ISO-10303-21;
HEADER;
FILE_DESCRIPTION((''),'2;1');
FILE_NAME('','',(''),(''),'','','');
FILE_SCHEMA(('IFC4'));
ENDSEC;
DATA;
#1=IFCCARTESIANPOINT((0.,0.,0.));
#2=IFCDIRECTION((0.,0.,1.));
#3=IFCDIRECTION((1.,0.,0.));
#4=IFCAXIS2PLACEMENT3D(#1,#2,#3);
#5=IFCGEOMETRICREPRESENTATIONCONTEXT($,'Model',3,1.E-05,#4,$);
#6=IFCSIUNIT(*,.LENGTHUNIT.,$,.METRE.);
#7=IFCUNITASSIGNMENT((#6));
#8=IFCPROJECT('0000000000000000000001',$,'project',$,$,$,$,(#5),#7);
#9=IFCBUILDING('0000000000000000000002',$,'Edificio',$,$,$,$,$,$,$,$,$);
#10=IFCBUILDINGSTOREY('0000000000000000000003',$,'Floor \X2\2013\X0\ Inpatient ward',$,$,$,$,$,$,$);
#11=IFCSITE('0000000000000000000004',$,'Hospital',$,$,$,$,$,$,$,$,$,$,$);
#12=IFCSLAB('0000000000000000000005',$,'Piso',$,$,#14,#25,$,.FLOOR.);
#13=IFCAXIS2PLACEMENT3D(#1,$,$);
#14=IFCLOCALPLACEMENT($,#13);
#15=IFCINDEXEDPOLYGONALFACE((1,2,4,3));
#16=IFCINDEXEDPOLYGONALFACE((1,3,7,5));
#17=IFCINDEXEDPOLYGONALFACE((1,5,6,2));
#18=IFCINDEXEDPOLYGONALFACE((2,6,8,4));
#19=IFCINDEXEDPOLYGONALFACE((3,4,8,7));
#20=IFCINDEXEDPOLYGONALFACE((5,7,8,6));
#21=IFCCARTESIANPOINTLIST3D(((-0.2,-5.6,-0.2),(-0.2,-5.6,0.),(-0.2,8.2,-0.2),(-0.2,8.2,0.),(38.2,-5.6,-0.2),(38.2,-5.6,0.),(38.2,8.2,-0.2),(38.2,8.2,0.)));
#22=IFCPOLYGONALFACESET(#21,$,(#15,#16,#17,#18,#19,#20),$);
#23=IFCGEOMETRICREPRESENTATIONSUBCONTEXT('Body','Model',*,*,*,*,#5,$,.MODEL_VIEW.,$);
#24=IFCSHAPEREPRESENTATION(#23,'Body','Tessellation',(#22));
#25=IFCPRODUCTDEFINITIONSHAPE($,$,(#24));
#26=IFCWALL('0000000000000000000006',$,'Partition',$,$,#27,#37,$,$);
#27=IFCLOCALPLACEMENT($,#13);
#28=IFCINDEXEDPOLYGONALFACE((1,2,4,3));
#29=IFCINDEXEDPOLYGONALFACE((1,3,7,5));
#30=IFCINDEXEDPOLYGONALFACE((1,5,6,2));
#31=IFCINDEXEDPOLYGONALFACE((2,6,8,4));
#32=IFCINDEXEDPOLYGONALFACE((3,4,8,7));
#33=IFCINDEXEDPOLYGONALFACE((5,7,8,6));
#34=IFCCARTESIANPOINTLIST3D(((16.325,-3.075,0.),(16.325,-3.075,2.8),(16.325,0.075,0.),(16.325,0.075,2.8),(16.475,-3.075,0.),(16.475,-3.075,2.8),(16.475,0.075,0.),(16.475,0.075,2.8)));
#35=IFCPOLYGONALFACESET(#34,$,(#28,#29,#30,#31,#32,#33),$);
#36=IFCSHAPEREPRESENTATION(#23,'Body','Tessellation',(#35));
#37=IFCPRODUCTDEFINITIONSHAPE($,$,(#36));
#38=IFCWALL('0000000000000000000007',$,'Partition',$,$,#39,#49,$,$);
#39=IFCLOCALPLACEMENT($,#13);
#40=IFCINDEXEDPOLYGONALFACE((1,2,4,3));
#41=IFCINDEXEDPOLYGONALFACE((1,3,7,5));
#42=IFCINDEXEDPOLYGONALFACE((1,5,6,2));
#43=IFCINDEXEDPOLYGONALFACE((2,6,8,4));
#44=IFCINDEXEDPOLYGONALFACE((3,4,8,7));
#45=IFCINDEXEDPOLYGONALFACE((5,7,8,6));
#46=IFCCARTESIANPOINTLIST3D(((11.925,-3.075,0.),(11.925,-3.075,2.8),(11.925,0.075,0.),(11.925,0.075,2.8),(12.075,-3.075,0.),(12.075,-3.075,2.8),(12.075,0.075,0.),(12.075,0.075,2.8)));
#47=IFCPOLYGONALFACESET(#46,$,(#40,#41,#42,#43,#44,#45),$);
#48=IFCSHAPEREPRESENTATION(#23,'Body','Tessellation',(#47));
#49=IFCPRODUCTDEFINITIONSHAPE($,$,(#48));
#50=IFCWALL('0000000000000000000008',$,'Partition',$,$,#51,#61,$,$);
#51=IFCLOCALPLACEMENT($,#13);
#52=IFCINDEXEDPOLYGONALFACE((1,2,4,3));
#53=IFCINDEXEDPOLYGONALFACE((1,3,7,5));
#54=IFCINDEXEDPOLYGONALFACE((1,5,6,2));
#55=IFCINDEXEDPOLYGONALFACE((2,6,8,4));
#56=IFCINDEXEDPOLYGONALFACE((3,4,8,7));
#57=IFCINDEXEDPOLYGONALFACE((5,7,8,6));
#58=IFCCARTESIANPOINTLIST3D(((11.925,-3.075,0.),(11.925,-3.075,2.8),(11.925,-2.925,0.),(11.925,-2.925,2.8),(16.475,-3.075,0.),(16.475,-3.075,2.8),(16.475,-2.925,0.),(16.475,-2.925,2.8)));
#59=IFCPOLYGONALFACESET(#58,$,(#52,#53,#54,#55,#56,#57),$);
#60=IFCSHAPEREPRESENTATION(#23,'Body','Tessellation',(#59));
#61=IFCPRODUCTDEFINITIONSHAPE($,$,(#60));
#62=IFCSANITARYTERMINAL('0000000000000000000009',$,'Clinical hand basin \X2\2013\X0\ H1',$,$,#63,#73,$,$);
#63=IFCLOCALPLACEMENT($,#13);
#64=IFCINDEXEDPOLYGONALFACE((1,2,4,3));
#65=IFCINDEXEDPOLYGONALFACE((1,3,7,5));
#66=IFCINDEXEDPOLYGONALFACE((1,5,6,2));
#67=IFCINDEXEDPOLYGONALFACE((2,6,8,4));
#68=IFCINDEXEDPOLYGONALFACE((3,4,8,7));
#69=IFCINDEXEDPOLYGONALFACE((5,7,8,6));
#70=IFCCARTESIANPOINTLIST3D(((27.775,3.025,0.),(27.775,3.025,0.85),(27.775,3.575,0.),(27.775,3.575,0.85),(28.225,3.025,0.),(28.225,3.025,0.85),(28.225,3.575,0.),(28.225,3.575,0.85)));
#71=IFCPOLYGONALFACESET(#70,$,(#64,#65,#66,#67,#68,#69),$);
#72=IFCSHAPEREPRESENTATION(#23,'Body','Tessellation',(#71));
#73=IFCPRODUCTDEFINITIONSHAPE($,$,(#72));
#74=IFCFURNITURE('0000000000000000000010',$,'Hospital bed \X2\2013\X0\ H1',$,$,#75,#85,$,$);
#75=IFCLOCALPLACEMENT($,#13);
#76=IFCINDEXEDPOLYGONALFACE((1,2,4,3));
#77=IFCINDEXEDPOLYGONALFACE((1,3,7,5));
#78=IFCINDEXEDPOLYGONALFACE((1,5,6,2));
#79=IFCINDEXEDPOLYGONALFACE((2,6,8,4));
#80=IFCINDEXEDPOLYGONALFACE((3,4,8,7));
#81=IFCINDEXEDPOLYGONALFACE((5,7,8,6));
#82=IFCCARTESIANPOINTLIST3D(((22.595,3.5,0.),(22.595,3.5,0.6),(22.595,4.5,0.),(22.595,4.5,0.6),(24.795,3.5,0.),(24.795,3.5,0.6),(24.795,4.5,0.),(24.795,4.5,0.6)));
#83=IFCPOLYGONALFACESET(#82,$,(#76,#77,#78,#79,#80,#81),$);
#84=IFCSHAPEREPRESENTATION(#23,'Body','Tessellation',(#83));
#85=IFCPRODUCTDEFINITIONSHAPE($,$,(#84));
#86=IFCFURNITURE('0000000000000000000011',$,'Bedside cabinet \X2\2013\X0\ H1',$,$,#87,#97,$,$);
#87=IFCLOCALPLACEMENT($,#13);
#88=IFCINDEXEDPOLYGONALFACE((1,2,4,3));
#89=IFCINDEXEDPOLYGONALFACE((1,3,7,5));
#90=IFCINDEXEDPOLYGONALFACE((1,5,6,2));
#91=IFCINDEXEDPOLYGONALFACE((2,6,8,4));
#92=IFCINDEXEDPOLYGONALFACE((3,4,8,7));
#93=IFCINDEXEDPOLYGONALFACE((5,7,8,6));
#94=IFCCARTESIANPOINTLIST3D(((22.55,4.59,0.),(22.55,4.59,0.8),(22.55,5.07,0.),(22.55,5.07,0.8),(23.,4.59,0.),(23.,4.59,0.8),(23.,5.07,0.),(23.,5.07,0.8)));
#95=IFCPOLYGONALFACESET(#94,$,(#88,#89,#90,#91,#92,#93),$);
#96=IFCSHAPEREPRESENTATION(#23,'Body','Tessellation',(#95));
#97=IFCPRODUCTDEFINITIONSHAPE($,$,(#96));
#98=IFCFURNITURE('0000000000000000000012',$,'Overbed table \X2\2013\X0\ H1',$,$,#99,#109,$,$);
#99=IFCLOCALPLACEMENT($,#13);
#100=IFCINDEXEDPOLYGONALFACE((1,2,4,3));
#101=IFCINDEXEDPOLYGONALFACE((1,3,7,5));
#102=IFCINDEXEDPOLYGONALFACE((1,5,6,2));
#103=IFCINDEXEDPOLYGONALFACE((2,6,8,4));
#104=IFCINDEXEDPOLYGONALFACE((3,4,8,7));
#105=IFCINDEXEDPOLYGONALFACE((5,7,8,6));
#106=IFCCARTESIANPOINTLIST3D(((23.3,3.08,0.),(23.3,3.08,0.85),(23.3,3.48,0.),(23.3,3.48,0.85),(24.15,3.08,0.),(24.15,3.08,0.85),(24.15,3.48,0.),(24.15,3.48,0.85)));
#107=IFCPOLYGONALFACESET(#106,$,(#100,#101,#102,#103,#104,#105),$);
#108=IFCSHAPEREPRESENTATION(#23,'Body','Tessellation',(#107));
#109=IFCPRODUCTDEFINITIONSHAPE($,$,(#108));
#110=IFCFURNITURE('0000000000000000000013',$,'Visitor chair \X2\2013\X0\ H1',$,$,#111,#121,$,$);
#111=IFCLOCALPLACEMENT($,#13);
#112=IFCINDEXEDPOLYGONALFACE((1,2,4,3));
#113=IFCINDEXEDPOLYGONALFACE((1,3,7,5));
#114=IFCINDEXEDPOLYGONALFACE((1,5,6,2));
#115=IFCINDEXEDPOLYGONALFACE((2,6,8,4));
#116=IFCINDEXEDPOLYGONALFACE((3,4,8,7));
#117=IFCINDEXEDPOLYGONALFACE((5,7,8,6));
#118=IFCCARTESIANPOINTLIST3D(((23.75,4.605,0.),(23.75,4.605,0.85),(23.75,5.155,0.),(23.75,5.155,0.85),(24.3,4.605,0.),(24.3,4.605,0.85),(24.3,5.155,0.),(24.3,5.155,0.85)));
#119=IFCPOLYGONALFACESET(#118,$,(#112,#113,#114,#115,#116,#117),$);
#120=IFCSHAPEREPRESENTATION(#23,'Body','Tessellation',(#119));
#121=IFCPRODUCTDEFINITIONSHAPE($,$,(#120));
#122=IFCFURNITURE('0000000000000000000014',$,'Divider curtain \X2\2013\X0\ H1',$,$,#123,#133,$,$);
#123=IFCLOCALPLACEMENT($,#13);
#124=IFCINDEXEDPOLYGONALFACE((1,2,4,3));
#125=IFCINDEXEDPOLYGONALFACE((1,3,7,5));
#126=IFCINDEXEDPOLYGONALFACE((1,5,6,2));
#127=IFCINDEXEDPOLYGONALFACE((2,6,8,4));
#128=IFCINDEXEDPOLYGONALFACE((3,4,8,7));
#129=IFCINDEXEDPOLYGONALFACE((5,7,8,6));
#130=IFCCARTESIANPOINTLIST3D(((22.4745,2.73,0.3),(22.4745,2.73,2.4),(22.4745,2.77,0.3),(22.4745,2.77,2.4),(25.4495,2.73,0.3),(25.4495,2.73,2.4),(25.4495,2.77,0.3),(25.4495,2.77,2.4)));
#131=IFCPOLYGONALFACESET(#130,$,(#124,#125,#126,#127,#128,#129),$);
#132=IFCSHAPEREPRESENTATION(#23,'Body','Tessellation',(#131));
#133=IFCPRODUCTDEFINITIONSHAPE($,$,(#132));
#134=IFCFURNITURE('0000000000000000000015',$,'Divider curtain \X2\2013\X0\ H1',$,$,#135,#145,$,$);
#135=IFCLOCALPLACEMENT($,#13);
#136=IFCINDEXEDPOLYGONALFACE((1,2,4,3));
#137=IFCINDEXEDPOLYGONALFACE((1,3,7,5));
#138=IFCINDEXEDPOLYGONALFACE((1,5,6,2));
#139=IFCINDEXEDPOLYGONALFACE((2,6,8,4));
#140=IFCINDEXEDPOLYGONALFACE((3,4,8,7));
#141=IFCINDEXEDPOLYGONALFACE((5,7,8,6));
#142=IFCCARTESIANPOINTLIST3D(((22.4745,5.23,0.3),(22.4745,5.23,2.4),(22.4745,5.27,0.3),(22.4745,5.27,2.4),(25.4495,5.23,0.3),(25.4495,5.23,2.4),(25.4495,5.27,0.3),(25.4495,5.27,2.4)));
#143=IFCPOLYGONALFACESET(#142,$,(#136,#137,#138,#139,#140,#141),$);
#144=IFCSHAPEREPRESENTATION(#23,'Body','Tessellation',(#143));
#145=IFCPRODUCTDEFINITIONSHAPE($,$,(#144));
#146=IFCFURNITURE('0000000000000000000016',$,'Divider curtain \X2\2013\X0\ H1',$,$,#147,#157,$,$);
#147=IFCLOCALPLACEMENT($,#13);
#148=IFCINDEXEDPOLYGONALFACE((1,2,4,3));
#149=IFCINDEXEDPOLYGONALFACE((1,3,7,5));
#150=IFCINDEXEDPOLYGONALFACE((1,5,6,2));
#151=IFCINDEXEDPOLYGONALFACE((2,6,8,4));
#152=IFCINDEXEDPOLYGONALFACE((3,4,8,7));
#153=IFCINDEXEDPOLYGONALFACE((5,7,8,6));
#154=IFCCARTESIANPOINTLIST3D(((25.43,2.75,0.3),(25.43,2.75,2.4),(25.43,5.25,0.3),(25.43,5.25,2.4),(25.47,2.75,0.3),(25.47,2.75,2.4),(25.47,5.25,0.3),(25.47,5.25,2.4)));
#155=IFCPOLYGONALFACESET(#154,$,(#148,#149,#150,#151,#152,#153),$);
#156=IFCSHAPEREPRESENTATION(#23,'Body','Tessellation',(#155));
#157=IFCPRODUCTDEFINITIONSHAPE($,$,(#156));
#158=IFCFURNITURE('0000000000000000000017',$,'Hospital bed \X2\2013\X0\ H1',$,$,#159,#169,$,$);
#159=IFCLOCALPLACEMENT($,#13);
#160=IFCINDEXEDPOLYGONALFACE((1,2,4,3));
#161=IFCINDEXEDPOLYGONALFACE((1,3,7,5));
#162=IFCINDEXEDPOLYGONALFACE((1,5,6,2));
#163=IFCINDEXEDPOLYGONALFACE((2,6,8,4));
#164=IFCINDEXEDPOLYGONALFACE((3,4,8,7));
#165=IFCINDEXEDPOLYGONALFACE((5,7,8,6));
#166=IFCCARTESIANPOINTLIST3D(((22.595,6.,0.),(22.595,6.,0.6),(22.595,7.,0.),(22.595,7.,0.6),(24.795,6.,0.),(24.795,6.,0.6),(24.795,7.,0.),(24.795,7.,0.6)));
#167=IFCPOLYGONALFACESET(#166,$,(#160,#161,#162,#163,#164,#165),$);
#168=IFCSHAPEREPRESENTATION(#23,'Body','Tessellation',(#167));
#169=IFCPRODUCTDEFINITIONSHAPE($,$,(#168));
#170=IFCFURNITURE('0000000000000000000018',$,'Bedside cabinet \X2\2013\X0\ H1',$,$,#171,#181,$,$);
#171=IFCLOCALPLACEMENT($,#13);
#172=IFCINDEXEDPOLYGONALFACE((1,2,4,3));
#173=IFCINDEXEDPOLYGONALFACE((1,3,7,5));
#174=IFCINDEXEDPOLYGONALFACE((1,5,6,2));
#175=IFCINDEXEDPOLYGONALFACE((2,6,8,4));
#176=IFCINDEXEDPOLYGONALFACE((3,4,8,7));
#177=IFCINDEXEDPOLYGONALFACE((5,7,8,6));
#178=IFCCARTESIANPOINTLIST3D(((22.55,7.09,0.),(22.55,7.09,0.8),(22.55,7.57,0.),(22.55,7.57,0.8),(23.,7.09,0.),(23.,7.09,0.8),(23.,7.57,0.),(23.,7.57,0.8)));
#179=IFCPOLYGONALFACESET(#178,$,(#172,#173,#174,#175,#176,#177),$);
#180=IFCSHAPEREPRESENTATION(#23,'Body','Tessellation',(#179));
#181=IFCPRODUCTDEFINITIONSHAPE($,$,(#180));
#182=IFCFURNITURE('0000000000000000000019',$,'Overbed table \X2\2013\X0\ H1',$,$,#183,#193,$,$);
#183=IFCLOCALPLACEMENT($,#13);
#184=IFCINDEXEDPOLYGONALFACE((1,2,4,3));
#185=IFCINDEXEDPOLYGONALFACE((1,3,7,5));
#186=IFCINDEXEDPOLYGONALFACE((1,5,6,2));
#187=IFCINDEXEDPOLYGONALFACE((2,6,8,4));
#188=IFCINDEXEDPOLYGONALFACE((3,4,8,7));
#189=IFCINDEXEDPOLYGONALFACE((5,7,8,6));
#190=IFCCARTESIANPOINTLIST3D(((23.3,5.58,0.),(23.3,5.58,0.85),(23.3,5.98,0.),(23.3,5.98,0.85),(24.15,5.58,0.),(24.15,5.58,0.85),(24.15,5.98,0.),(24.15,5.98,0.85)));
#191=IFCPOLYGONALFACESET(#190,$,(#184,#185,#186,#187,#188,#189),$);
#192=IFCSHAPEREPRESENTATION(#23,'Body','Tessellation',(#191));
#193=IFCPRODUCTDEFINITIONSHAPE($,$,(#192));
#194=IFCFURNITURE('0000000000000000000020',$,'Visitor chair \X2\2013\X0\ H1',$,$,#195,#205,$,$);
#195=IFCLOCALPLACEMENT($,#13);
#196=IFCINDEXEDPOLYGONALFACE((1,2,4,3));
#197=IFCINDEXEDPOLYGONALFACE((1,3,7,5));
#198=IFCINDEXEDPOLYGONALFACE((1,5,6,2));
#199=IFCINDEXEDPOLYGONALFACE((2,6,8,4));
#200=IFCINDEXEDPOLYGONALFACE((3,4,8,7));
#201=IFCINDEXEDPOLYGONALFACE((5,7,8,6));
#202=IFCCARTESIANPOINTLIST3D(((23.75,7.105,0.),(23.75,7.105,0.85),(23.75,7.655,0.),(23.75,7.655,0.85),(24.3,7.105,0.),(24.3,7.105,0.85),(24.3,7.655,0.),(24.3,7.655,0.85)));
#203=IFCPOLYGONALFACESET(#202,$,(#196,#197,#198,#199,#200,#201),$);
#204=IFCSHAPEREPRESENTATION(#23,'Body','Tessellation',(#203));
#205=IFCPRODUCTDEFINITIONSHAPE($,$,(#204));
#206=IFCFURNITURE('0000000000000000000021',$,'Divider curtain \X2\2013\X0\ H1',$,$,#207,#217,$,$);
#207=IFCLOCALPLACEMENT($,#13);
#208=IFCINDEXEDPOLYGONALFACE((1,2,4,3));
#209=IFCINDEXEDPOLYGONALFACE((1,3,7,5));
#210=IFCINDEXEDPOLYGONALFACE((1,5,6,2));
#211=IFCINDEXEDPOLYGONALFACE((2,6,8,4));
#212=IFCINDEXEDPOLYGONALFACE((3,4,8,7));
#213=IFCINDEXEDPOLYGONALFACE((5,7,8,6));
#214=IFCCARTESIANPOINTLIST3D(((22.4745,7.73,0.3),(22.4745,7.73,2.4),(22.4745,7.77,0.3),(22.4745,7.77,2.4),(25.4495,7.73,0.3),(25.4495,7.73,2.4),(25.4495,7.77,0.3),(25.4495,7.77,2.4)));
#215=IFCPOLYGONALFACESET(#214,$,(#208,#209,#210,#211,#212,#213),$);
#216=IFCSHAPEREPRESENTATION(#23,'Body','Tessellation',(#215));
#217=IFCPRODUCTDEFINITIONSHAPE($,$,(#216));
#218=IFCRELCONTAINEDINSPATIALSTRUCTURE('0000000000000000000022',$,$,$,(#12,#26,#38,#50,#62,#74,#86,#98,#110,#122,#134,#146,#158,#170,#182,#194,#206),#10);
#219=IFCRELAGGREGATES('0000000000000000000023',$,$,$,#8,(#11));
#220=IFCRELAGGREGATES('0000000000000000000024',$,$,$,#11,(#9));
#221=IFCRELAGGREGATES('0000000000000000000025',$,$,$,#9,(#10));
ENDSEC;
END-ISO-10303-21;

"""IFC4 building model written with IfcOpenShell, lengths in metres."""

from ifc_helpers import new_model, si_unit, frame, origin_with_axes, context, subcontext, project, spatial, line, indexed_curve, outline, extrude, element, save


model = new_model("IFC4")

# Units and contexts
model_context = context("Model", 3, precision=1e-05, world=origin_with_axes())
body_context = subcontext(model_context, "Body", "Model", "MODEL_VIEW")
ifc_project = project(units=[si_unit("LENGTHUNIT", "METRE")], contexts=[model_context])

# Site, building, storey
site = spatial("IfcSite", under=ifc_project, Name="Hospital")
building = spatial("IfcBuilding", under=site, Name="Edificio")
storey = spatial("IfcBuildingStorey", under=building, Name="Floor – Inpatient ward")

# Slab
element("IfcSlab", 1, inside=storey, Name="Piso", PredefinedType="FLOOR", context=body_context, shape_type="SweptSolid", body=[
    extrude(outline(indexed_curve([(0.0, 0.0), (38.4, 0.0), (38.4, 13.8), (0.0, 13.8)], segments=[line(1, 2, 3, 4, 1)])), frame((-0.2, -5.6, -0.2), z_axis=(0.0, 0.0, 1.0), x_axis=(1.0, 0.0, 0.0)), (0.0, 0.0, 1.0), 0.2),
])

# Walls
element("IfcWall", 2, inside=storey, Name="Partition", context=body_context, shape_type="SweptSolid", body=[
    extrude(outline(indexed_curve([(0.0, 0.0), (0.15, 0.0), (0.15, 3.15), (0.0, 3.15)], segments=[line(1, 2, 3, 4, 1)])), frame((16.325, -3.075, 0.0), z_axis=(0.0, 0.0, 1.0), x_axis=(1.0, 0.0, 0.0)), (0.0, 0.0, 1.0), 2.8),
])
element("IfcWall", 3, inside=storey, Name="Partition", context=body_context, shape_type="SweptSolid", body=[
    extrude(outline(indexed_curve([(0.0, 0.0), (0.15, 0.0), (0.15, 3.15), (0.0, 3.15)], segments=[line(1, 2, 3, 4, 1)])), frame((11.925, -3.075, 0.0), z_axis=(0.0, 0.0, 1.0), x_axis=(1.0, 0.0, 0.0)), (0.0, 0.0, 1.0), 2.8),
])
element("IfcWall", 4, inside=storey, Name="Partition", context=body_context, shape_type="SweptSolid", body=[
    extrude(outline(indexed_curve([(0.0, 0.0), (4.55, 0.0), (4.55, 0.15), (0.0, 0.15)], segments=[line(1, 2, 3, 4, 1)])), frame((11.925, -3.075, 0.0), z_axis=(0.0, 0.0, 1.0), x_axis=(1.0, 0.0, 0.0)), (0.0, 0.0, 1.0), 2.8),
])

# Sanitary terminal
element("IfcSanitaryTerminal", 5, inside=storey, Name="Clinical hand basin – H1", context=body_context, shape_type="SweptSolid", body=[
    extrude(outline(indexed_curve([(0.0, 0.0), (0.45, 0.0), (0.45, 0.55), (0.0, 0.55)], segments=[line(1, 2, 3, 4, 1)])), frame((27.775, 3.025, 0.0), z_axis=(0.0, 0.0, 1.0), x_axis=(1.0, 0.0, 0.0)), (0.0, 0.0, 1.0), 0.85),
])

# Furniture
element("IfcFurniture", 6, inside=storey, Name="Hospital bed – H1", context=body_context, shape_type="SweptSolid", body=[
    extrude(outline(indexed_curve([(0.0, 0.0), (2.2, 0.0), (2.2, 1.0), (0.0, 1.0)], segments=[line(1, 2, 3, 4, 1)])), frame((22.595, 3.5, 0.0), z_axis=(0.0, 0.0, 1.0), x_axis=(1.0, 0.0, 0.0)), (0.0, 0.0, 1.0), 0.6),
])
element("IfcFurniture", 7, inside=storey, Name="Bedside cabinet – H1", context=body_context, shape_type="SweptSolid", body=[
    extrude(outline(indexed_curve([(0.0, 0.0), (0.45, 0.0), (0.45, 0.48), (0.0, 0.48)], segments=[line(1, 2, 3, 4, 1)])), frame((22.55, 4.59, 0.0), z_axis=(0.0, 0.0, 1.0), x_axis=(1.0, 0.0, 0.0)), (0.0, 0.0, 1.0), 0.8),
])
element("IfcFurniture", 8, inside=storey, Name="Overbed table – H1", context=body_context, shape_type="SweptSolid", body=[
    extrude(outline(indexed_curve([(0.0, 0.0), (0.85, 0.0), (0.85, 0.4), (0.0, 0.4)], segments=[line(1, 2, 3, 4, 1)])), frame((23.3, 3.08, 0.0), z_axis=(0.0, 0.0, 1.0), x_axis=(1.0, 0.0, 0.0)), (0.0, 0.0, 1.0), 0.85),
])
element("IfcFurniture", 9, inside=storey, Name="Visitor chair – H1", context=body_context, shape_type="SweptSolid", body=[
    extrude(outline(indexed_curve([(0.0, 0.0), (0.55, 0.0), (0.55, 0.55), (0.0, 0.55)], segments=[line(1, 2, 3, 4, 1)])), frame((23.75, 4.605, 0.0), z_axis=(0.0, 0.0, 1.0), x_axis=(1.0, 0.0, 0.0)), (0.0, 0.0, 1.0), 0.85),
])
element("IfcFurniture", 10, inside=storey, Name="Divider curtain – H1", context=body_context, shape_type="SweptSolid", body=[
    extrude(outline(indexed_curve([(0.0, 0.0), (2.975, 0.0), (2.975, 0.04), (0.0, 0.04)], segments=[line(1, 2, 3, 4, 1)])), frame((22.4745, 2.73, 0.3), z_axis=(0.0, 0.0, 1.0), x_axis=(1.0, 0.0, 0.0)), (0.0, 0.0, 1.0), 2.1),
])
element("IfcFurniture", 11, inside=storey, Name="Divider curtain – H1", context=body_context, shape_type="SweptSolid", body=[
    extrude(outline(indexed_curve([(0.0, 0.0), (2.975, 0.0), (2.975, 0.04), (0.0, 0.04)], segments=[line(1, 2, 3, 4, 1)])), frame((22.4745, 5.23, 0.3), z_axis=(0.0, 0.0, 1.0), x_axis=(1.0, 0.0, 0.0)), (0.0, 0.0, 1.0), 2.1),
])
element("IfcFurniture", 12, inside=storey, Name="Divider curtain – H1", context=body_context, shape_type="SweptSolid", body=[
    extrude(outline(indexed_curve([(0.0, 0.0), (0.04, 0.0), (0.04, 2.5), (0.0, 2.5)], segments=[line(1, 2, 3, 4, 1)])), frame((25.43, 2.75, 0.3), z_axis=(0.0, 0.0, 1.0), x_axis=(1.0, 0.0, 0.0)), (0.0, 0.0, 1.0), 2.1),
])
element("IfcFurniture", 13, inside=storey, Name="Hospital bed – H1", context=body_context, shape_type="SweptSolid", body=[
    extrude(outline(indexed_curve([(0.0, 0.0), (2.2, 0.0), (2.2, 1.0), (0.0, 1.0)], segments=[line(1, 2, 3, 4, 1)])), frame((22.595, 6.0, 0.0), z_axis=(0.0, 0.0, 1.0), x_axis=(1.0, 0.0, 0.0)), (0.0, 0.0, 1.0), 0.6),
])
element("IfcFurniture", 14, inside=storey, Name="Bedside cabinet – H1", context=body_context, shape_type="SweptSolid", body=[
    extrude(outline(indexed_curve([(0.0, 0.0), (0.45, 0.0), (0.45, 0.48), (0.0, 0.48)], segments=[line(1, 2, 3, 4, 1)])), frame((22.55, 7.09, 0.0), z_axis=(0.0, 0.0, 1.0), x_axis=(1.0, 0.0, 0.0)), (0.0, 0.0, 1.0), 0.8),
])
element("IfcFurniture", 15, inside=storey, Name="Overbed table – H1", context=body_context, shape_type="SweptSolid", body=[
    extrude(outline(indexed_curve([(0.0, 0.0), (0.85, 0.0), (0.85, 0.4), (0.0, 0.4)], segments=[line(1, 2, 3, 4, 1)])), frame((23.3, 5.58, 0.0), z_axis=(0.0, 0.0, 1.0), x_axis=(1.0, 0.0, 0.0)), (0.0, 0.0, 1.0), 0.85),
])
element("IfcFurniture", 16, inside=storey, Name="Visitor chair – H1", context=body_context, shape_type="SweptSolid", body=[
    extrude(outline(indexed_curve([(0.0, 0.0), (0.55, 0.0), (0.55, 0.55), (0.0, 0.55)], segments=[line(1, 2, 3, 4, 1)])), frame((23.75, 7.105, 0.0), z_axis=(0.0, 0.0, 1.0), x_axis=(1.0, 0.0, 0.0)), (0.0, 0.0, 1.0), 0.85),
])
element("IfcFurniture", 17, inside=storey, Name="Divider curtain – H1", context=body_context, shape_type="SweptSolid", body=[
    extrude(outline(indexed_curve([(0.0, 0.0), (2.975, 0.0), (2.975, 0.04), (0.0, 0.04)], segments=[line(1, 2, 3, 4, 1)])), frame((22.4745, 7.73, 0.3), z_axis=(0.0, 0.0, 1.0), x_axis=(1.0, 0.0, 0.0)), (0.0, 0.0, 1.0), 2.1),
])

save(model, "model.ifc")
